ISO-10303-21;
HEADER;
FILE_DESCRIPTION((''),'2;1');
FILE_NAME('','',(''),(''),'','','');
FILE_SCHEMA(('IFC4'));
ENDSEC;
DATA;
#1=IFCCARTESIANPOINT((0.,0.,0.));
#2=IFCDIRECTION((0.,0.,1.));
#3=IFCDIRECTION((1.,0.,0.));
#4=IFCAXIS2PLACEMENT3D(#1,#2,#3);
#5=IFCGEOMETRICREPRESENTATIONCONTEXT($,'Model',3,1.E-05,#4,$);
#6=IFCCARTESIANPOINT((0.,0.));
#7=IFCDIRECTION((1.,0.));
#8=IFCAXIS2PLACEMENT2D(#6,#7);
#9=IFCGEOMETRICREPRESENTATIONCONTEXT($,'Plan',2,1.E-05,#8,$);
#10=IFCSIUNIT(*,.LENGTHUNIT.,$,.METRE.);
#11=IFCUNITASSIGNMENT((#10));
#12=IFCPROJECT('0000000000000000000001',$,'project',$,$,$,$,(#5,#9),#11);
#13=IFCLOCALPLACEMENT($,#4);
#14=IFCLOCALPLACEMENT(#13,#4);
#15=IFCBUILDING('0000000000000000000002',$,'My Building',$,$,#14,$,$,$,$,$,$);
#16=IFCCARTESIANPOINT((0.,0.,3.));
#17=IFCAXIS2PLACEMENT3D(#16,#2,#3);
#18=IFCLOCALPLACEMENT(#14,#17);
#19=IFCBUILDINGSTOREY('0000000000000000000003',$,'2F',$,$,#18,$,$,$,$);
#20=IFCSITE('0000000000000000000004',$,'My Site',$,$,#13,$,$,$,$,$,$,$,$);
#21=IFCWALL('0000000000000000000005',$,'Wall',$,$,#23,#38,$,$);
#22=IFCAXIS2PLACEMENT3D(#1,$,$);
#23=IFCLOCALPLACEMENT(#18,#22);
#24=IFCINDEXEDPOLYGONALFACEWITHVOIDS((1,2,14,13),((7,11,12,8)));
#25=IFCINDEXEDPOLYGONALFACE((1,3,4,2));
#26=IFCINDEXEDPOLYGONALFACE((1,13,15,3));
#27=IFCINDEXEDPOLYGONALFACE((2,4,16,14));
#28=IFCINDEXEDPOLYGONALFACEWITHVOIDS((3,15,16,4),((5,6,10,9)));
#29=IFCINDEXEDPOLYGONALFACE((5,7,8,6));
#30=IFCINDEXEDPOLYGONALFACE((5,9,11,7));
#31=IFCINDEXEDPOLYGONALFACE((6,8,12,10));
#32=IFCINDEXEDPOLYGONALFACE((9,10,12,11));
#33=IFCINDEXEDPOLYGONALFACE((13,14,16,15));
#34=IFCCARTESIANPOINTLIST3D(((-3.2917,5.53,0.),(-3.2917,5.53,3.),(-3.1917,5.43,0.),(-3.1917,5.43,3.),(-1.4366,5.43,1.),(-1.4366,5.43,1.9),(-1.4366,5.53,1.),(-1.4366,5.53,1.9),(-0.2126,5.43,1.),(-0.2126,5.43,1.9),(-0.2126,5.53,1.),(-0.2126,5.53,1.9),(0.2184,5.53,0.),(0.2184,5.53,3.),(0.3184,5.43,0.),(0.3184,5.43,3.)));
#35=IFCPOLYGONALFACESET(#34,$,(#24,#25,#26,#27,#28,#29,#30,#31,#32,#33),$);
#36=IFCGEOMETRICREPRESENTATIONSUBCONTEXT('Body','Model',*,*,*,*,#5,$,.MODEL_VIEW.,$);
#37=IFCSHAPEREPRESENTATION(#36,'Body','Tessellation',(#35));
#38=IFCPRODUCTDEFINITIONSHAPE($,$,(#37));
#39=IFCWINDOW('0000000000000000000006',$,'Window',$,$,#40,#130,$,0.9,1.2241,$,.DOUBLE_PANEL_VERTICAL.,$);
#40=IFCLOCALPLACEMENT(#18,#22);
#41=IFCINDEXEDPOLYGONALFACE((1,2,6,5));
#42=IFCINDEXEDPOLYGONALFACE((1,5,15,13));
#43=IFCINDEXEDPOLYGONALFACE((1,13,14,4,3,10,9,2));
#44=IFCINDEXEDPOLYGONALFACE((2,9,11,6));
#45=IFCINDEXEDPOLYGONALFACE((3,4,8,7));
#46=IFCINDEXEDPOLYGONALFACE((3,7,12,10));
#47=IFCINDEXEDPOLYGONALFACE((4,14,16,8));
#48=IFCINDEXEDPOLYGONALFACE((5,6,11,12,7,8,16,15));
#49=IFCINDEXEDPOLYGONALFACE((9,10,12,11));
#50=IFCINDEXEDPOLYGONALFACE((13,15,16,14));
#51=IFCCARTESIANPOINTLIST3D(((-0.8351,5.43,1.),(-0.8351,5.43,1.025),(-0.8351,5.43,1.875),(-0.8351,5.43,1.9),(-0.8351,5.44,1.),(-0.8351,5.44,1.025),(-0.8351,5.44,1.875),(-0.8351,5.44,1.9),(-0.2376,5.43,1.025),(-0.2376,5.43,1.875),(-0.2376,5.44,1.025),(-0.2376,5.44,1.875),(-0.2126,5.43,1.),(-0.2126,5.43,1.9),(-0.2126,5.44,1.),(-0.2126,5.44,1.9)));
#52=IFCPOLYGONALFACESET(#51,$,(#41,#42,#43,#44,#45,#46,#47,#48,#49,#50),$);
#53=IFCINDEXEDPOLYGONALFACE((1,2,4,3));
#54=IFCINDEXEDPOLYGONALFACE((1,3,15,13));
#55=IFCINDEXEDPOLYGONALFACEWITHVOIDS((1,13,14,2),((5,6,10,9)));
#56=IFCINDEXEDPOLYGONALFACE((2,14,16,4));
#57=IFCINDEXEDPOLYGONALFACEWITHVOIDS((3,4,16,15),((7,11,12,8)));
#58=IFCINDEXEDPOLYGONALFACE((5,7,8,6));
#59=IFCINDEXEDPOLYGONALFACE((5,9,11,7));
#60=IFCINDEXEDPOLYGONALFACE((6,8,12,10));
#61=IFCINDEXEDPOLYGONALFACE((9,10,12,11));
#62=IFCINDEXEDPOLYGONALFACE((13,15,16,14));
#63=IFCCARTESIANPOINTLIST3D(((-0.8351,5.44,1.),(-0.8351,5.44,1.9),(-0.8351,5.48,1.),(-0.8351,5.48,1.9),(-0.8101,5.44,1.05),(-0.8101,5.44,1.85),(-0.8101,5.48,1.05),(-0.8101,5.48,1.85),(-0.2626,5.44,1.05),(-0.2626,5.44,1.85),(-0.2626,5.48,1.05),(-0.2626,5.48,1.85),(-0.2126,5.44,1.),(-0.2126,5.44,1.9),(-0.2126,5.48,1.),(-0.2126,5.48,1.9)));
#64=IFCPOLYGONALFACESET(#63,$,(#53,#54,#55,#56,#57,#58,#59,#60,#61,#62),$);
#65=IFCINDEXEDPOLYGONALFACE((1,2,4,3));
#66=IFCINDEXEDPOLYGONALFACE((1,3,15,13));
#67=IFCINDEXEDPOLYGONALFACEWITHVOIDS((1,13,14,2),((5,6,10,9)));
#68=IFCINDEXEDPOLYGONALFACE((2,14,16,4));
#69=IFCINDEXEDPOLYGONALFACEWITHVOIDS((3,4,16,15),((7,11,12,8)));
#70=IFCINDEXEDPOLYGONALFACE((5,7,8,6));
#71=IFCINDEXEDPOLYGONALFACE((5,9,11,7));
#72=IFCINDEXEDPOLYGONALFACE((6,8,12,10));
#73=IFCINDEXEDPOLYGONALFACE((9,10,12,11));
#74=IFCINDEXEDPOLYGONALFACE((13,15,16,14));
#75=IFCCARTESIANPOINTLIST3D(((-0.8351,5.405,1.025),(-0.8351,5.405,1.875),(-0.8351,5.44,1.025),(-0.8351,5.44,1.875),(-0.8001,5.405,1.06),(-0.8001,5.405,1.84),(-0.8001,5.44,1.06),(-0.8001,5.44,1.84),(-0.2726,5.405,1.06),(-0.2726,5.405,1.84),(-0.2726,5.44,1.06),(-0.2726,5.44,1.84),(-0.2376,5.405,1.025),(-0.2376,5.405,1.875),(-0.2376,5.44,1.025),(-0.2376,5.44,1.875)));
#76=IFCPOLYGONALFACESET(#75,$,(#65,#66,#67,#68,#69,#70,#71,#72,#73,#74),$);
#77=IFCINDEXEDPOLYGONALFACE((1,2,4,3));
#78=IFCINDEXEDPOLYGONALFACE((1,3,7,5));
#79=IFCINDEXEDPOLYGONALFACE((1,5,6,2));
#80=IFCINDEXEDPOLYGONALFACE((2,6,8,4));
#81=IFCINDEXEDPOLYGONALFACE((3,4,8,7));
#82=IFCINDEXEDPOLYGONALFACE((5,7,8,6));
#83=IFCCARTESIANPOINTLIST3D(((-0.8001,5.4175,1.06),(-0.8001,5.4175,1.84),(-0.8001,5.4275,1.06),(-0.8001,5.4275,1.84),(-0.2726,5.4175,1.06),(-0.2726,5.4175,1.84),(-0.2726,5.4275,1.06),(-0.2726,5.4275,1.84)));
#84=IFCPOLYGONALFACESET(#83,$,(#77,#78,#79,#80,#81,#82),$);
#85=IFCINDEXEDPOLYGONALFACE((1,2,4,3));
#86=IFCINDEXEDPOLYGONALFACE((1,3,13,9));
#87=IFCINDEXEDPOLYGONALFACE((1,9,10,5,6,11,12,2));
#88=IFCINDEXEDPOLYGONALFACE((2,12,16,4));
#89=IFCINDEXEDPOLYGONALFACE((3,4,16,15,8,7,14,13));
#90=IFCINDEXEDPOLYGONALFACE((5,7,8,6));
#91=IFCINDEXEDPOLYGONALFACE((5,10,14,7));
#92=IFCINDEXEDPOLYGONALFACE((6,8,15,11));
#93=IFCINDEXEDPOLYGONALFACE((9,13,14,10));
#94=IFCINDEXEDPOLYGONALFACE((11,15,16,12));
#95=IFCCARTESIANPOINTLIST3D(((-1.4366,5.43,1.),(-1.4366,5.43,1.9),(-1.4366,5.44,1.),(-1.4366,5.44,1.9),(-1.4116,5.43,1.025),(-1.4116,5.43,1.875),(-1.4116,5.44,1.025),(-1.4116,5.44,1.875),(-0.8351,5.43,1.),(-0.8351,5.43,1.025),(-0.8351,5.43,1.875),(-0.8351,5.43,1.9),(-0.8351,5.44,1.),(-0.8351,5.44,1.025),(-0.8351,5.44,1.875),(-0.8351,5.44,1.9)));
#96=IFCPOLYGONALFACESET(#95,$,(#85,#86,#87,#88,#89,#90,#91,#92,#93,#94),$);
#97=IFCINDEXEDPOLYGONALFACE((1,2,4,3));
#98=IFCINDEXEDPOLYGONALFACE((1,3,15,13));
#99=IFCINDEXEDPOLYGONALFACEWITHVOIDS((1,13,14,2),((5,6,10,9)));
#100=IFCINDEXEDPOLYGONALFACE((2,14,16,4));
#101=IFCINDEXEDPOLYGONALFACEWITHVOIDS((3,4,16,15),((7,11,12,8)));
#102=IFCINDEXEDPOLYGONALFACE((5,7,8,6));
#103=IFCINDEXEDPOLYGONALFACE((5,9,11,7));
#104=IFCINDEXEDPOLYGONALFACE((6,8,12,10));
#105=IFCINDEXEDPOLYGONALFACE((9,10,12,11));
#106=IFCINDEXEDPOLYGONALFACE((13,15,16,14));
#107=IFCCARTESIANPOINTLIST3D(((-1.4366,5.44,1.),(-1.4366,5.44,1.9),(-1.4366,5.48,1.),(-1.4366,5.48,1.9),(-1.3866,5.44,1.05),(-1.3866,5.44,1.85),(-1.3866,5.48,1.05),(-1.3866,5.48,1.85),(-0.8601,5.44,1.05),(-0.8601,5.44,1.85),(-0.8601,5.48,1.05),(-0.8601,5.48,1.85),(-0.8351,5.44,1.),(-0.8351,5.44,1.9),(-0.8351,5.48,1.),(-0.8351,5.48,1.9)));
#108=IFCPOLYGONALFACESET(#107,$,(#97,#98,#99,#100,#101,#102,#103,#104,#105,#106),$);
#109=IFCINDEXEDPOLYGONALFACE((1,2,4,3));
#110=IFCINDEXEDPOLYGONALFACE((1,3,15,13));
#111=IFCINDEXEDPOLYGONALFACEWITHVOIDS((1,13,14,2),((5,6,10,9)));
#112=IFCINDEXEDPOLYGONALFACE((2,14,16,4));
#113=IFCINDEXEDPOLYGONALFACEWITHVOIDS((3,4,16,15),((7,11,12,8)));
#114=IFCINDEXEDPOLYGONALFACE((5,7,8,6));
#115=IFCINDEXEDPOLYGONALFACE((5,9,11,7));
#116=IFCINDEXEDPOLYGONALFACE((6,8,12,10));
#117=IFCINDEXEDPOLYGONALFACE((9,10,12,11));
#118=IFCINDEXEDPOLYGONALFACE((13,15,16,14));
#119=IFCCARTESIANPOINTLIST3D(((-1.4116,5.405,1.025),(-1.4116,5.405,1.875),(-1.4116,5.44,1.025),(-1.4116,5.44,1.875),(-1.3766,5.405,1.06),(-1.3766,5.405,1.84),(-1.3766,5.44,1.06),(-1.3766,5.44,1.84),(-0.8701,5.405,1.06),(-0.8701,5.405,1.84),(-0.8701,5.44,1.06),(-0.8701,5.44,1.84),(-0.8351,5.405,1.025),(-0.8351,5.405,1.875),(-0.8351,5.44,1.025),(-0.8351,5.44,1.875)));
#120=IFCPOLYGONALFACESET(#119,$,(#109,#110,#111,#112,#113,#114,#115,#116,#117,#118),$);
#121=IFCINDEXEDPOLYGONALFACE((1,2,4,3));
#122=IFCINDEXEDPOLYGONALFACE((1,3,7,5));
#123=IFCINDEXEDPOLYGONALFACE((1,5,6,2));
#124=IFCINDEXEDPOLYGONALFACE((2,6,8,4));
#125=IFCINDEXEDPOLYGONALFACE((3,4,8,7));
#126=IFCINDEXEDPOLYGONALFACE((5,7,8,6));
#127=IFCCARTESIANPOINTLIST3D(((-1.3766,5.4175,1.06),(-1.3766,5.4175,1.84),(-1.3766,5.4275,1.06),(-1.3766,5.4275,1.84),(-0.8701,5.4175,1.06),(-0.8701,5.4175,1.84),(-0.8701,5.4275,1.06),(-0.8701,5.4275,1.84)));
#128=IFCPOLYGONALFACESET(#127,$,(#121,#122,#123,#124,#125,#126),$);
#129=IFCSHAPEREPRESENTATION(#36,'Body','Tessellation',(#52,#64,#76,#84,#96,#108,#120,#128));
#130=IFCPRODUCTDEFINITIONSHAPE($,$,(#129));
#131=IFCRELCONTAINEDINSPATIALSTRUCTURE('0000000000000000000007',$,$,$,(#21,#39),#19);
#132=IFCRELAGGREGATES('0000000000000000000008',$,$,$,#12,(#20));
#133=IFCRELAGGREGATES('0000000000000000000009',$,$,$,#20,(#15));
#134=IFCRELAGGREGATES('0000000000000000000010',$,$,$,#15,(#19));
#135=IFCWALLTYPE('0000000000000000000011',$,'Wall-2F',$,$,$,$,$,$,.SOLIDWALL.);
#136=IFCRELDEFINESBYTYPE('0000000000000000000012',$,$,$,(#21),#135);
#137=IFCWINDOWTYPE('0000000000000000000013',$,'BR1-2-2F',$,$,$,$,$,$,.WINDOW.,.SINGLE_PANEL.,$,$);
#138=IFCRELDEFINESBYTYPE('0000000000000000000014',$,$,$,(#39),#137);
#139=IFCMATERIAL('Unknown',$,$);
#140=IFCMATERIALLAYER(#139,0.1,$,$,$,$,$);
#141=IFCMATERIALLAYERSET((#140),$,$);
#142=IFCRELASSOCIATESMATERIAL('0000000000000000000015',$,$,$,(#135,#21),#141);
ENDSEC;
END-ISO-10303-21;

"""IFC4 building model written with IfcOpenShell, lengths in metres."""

from ifc_helpers import new_model, entity, si_unit, frame, origin_with_axes, origin_2d_with_axis, place, context, subcontext, project, spatial, line, indexed_curve, outline, extrude, shape, source, transform, mapped, material, layer, layer_set, layer_usage, type_object, type_shapes, element, fill, save


model = new_model("IFC4")

# Units and contexts
model_context = context("Model", 3, precision=1e-05, world=origin_with_axes())
plan_context = context("Plan", 2, precision=1e-05, world=origin_2d_with_axis())
body_context_1 = subcontext(model_context, "Body", "Model", "MODEL_VIEW")
body_context_2 = subcontext(plan_context, "Body", "Plan", "PLAN_VIEW")
ifc_project = project(units=[si_unit("LENGTHUNIT", "METRE")], contexts=[model_context, plan_context])

# Site, building, storey
site_placement = place(None, origin_with_axes())
site = spatial("IfcSite", under=ifc_project, at=site_placement, Name="My Site")
building_placement = place(site_placement, origin_with_axes())
building = spatial("IfcBuilding", under=site, at=building_placement, Name="My Building")
storey_placement = place(building_placement, frame((0.0, 0.0, 3.0), z_axis=(0.0, 0.0, 1.0), x_axis=(1.0, 0.0, 0.0)))
storey = spatial("IfcBuildingStorey", under=building, at=storey_placement, Name="2F")

# Shared definitions
ifc_material = material(Name="Unknown")

# Shared definitions
ifc_layer = layer(ifc_material, 0.1)
ifc_layer_set = layer_set([ifc_layer])
wall_type = type_object("IfcWallType", Name="Wall-2F", PredefinedType="SOLIDWALL", material=ifc_layer_set)

# Wall, opening, window
ifc_layer_usage_1 = layer_usage(ifc_layer_set, "AXIS2", "POSITIVE", 0.0)
wall_1_placement = place(storey_placement, frame((0.2184, 5.53, 0.0), z_axis=(0.0, 0.0, 1.0), x_axis=(-1.0, 0.0, 0.0)))
wall_1 = element("IfcWall", 1, at=wall_1_placement, inside=storey, type_object=wall_type, material=ifc_layer_usage_1, Name="Wall", context=body_context_1, shape_type="SweptSolid", body=[
    extrude(outline(indexed_curve([(0.0, 0.0), (-0.1, 0.1), (3.41, 0.1), (3.51, 0.0)], segments=[line(1, 2, 3, 4, 1)])), origin_with_axes(), (0.0, 0.0, 1.0), 3.0),
])
shared_shape_1 = source(origin_with_axes(), body_context_1, "Body", "SweptSolid", [
    extrude(outline(indexed_curve([(0.0, 0.0), (1.2241, 0.0), (1.2241, 0.9), (0.0, 0.9)], segments=[line(1, 2, 3, 4, 1)])), frame((0.0, -0.6, 0.0), z_axis=(0.0, -1.0, 0.0), x_axis=(1.0, 0.0, 0.0)), (0.0, 0.0, -1.0), 1.2),
])
opening_1_placement = place(wall_1_placement, frame((0.4309, 0.0, 1.0), z_axis=(0.0, 0.0, 1.0), x_axis=(1.0, 0.0, 0.0)))
opening_1 = element("IfcOpeningElement", 2, at=opening_1_placement, cuts=wall_1, PredefinedType="OPENING", context=body_context_1, shape_type="MappedRepresentation", body=[
    mapped(shared_shape_1, transform((0.0, 0.0, 0.0), x_axis=(1.0, 0.0, 0.0), y_axis=(0.0, 1.0, 0.0), z_axis=(0.0, 0.0, 1.0), scale=1.0)),
])
window_type_1 = type_object("IfcWindowType", Name="BR1-2-2F", PartitioningType="SINGLE_PANEL", PredefinedType="WINDOW")
shared_shape_2 = source(origin_with_axes(), body_context_1, "Body", "SweptSolid", [
    extrude(outline(indexed_curve([(0.6225, 0.0), (0.0, 0.0), (0.0, 0.9), (0.6225, 0.9), (0.6225, 0.875), (0.025, 0.875), (0.025, 0.025), (0.6225, 0.025)], segments=[line(1, 2, 3, 4, 5, 6, 7, 8, 1)])), frame((0.0, 0.09, 0.0), z_axis=(0.0, -1.0, 0.0), x_axis=(1.0, 0.0, 0.0)), (0.0, 0.0, -1.0), 0.01),
    extrude(outline(indexed_curve([(0.0, 0.0), (0.6225, 0.0), (0.6225, 0.9), (0.0, 0.9)], segments=[line(1, 2, 3, 4, 1)]), holes=[indexed_curve([(0.05, 0.05), (0.5975, 0.05), (0.5975, 0.85), (0.05, 0.85)], segments=[line(1, 2, 3, 4, 1)])]), frame((0.0, 0.05, 0.0), z_axis=(0.0, -1.0, 0.0), x_axis=(1.0, 0.0, 0.0)), (0.0, 0.0, -1.0), 0.04),
    extrude(outline(indexed_curve([(0.0, 0.0), (0.5975, 0.0), (0.5975, 0.85), (0.0, 0.85)], segments=[line(1, 2, 3, 4, 1)]), holes=[indexed_curve([(0.035, 0.035), (0.5625, 0.035), (0.5625, 0.815), (0.035, 0.815)], segments=[line(1, 2, 3, 4, 1)])]), frame((0.025, 0.09, 0.025), z_axis=(0.0, -1.0, 0.0), x_axis=(1.0, 0.0, 0.0)), (0.0, 0.0, -1.0), 0.035),
    extrude(outline(indexed_curve([(0.035, 0.035), (0.5625, 0.035), (0.5625, 0.815), (0.035, 0.815)], segments=[line(1, 2, 3, 4, 1)])), frame((0.025, 0.1025, 0.025), z_axis=(0.0, -1.0, 0.0), x_axis=(1.0, 0.0, 0.0)), (0.0, 0.0, -1.0), 0.01),
    extrude(outline(indexed_curve([(0.0, 0.9), (0.6016, 0.9), (0.6016, 0.0), (0.0, 0.0), (0.0, 0.025), (0.5766, 0.025), (0.5766, 0.875), (0.0, 0.875)], segments=[line(1, 2, 3, 4, 5, 6, 7, 8, 1)])), frame((0.6225, 0.09, 0.0), z_axis=(0.0, -1.0, 0.0), x_axis=(1.0, 0.0, 0.0)), (0.0, 0.0, -1.0), 0.01),
    extrude(outline(indexed_curve([(0.0, 0.0), (0.6016, 0.0), (0.6016, 0.9), (0.0, 0.9)], segments=[line(1, 2, 3, 4, 1)]), holes=[indexed_curve([(0.025, 0.05), (0.5516, 0.05), (0.5516, 0.85), (0.025, 0.85)], segments=[line(1, 2, 3, 4, 1)])]), frame((0.6225, 0.05, 0.0), z_axis=(0.0, -1.0, 0.0), x_axis=(1.0, 0.0, 0.0)), (0.0, 0.0, -1.0), 0.04),
    extrude(outline(indexed_curve([(0.0, 0.0), (0.5766, 0.0), (0.5766, 0.85), (0.0, 0.85)], segments=[line(1, 2, 3, 4, 1)]), holes=[indexed_curve([(0.035, 0.035), (0.5416, 0.035), (0.5416, 0.815), (0.035, 0.815)], segments=[line(1, 2, 3, 4, 1)])]), frame((0.6225, 0.09, 0.025), z_axis=(0.0, -1.0, 0.0), x_axis=(1.0, 0.0, 0.0)), (0.0, 0.0, -1.0), 0.035),
    extrude(outline(indexed_curve([(0.035, 0.035), (0.5416, 0.035), (0.5416, 0.815), (0.035, 0.815)], segments=[line(1, 2, 3, 4, 1)])), frame((0.6225, 0.1025, 0.025), z_axis=(0.0, -1.0, 0.0), x_axis=(1.0, 0.0, 0.0)), (0.0, 0.0, -1.0), 0.01),
])
shared_shape_3 = source(origin_with_axes(), body_context_2, "Body", "Curve2D", [
    entity("IfcIndexedPolyCurve", entity("IfcCartesianPointList2D", [[0.05, 0.05], [0.5975, 0.05]])),
    entity("IfcIndexedPolyCurve", entity("IfcCartesianPointList2D", [[0.0, 0.1], [0.025, 0.1], [0.025, 0.09], [0.05, 0.09], [0.05, 0.05], [0.0, 0.05]]), [entity("IfcLineIndex", [1, 2, 3, 4, 5, 6, 1])]),
    entity("IfcIndexedPolyCurve", entity("IfcCartesianPointList2D", [[0.6225, 0.1], [0.6225, 0.1], [0.6225, 0.09], [0.5975, 0.09], [0.5975, 0.05], [0.6225, 0.05]])),
    entity("IfcIndexedPolyCurve", entity("IfcCartesianPointList2D", [[0.025, 0.09], [0.06, 0.09], [0.06, 0.125], [0.025, 0.125]]), [entity("IfcLineIndex", [1, 2, 3, 4, 1])]),
    entity("IfcIndexedPolyCurve", entity("IfcCartesianPointList2D", [[0.6225, 0.09], [0.5875, 0.09], [0.5875, 0.125], [0.6225, 0.125]]), [entity("IfcLineIndex", [1, 2, 3, 4, 1])]),
    entity("IfcIndexedPolyCurve", entity("IfcCartesianPointList2D", [[0.06, 0.09], [0.5875, 0.09]])),
    entity("IfcIndexedPolyCurve", entity("IfcCartesianPointList2D", [[0.06, 0.125], [0.5875, 0.125]])),
    entity("IfcIndexedPolyCurve", entity("IfcCartesianPointList2D", [[0.06, 0.1075], [0.5875, 0.1075]])),
    entity("IfcIndexedPolyCurve", entity("IfcCartesianPointList2D", [[0.6475, 0.05], [1.1741, 0.05]])),
    entity("IfcIndexedPolyCurve", entity("IfcCartesianPointList2D", [[0.6225, 0.1], [0.6225, 0.1], [0.6225, 0.09], [0.6475, 0.09], [0.6475, 0.05], [0.6225, 0.05]])),
    entity("IfcIndexedPolyCurve", entity("IfcCartesianPointList2D", [[1.2241, 0.1], [1.1991, 0.1], [1.1991, 0.09], [1.1741, 0.09], [1.1741, 0.05], [1.2241, 0.05]]), [entity("IfcLineIndex", [1, 2, 3, 4, 5, 6, 1])]),
    entity("IfcIndexedPolyCurve", entity("IfcCartesianPointList2D", [[0.6225, 0.09], [0.6575, 0.09], [0.6575, 0.125], [0.6225, 0.125]]), [entity("IfcLineIndex", [1, 2, 3, 4, 1])]),
    entity("IfcIndexedPolyCurve", entity("IfcCartesianPointList2D", [[1.1991, 0.09], [1.1641, 0.09], [1.1641, 0.125], [1.1991, 0.125]]), [entity("IfcLineIndex", [1, 2, 3, 4, 1])]),
    entity("IfcIndexedPolyCurve", entity("IfcCartesianPointList2D", [[0.6575, 0.09], [1.1641, 0.09]])),
    entity("IfcIndexedPolyCurve", entity("IfcCartesianPointList2D", [[0.6575, 0.125], [1.1641, 0.125]])),
    entity("IfcIndexedPolyCurve", entity("IfcCartesianPointList2D", [[0.6575, 0.1075], [1.1641, 0.1075]])),
])
type_shapes(window_type_1, [shared_shape_2, shared_shape_3])
window_1_placement = place(opening_1_placement, frame((0.0, 0.0, 0.0), z_axis=(0.0, 0.0, 1.0), x_axis=(1.0, 0.0, 0.0)))
window_1 = element("IfcWindow", 3, at=window_1_placement, inside=storey, type_object=window_type_1, Name="Window", OverallHeight=0.9, OverallWidth=1.2241, PartitioningType="DOUBLE_PANEL_VERTICAL", shapes=[
    shape(body_context_1, "Body", "MappedRepresentation", [mapped(shared_shape_2, transform((0.0, 0.0, 0.0), x_axis=(1.0, 0.0, 0.0), y_axis=(0.0, 1.0, 0.0), z_axis=(0.0, 0.0, 1.0), scale=1.0))]),
    shape(body_context_2, "Body", "MappedRepresentation", [mapped(shared_shape_3, transform((0.0, 0.0, 0.0), x_axis=(1.0, 0.0, 0.0), y_axis=(0.0, 1.0, 0.0), z_axis=(0.0, 0.0, 1.0), scale=1.0))]),
])
fill(opening_1, window_1)

save(model, "model.ifc")
